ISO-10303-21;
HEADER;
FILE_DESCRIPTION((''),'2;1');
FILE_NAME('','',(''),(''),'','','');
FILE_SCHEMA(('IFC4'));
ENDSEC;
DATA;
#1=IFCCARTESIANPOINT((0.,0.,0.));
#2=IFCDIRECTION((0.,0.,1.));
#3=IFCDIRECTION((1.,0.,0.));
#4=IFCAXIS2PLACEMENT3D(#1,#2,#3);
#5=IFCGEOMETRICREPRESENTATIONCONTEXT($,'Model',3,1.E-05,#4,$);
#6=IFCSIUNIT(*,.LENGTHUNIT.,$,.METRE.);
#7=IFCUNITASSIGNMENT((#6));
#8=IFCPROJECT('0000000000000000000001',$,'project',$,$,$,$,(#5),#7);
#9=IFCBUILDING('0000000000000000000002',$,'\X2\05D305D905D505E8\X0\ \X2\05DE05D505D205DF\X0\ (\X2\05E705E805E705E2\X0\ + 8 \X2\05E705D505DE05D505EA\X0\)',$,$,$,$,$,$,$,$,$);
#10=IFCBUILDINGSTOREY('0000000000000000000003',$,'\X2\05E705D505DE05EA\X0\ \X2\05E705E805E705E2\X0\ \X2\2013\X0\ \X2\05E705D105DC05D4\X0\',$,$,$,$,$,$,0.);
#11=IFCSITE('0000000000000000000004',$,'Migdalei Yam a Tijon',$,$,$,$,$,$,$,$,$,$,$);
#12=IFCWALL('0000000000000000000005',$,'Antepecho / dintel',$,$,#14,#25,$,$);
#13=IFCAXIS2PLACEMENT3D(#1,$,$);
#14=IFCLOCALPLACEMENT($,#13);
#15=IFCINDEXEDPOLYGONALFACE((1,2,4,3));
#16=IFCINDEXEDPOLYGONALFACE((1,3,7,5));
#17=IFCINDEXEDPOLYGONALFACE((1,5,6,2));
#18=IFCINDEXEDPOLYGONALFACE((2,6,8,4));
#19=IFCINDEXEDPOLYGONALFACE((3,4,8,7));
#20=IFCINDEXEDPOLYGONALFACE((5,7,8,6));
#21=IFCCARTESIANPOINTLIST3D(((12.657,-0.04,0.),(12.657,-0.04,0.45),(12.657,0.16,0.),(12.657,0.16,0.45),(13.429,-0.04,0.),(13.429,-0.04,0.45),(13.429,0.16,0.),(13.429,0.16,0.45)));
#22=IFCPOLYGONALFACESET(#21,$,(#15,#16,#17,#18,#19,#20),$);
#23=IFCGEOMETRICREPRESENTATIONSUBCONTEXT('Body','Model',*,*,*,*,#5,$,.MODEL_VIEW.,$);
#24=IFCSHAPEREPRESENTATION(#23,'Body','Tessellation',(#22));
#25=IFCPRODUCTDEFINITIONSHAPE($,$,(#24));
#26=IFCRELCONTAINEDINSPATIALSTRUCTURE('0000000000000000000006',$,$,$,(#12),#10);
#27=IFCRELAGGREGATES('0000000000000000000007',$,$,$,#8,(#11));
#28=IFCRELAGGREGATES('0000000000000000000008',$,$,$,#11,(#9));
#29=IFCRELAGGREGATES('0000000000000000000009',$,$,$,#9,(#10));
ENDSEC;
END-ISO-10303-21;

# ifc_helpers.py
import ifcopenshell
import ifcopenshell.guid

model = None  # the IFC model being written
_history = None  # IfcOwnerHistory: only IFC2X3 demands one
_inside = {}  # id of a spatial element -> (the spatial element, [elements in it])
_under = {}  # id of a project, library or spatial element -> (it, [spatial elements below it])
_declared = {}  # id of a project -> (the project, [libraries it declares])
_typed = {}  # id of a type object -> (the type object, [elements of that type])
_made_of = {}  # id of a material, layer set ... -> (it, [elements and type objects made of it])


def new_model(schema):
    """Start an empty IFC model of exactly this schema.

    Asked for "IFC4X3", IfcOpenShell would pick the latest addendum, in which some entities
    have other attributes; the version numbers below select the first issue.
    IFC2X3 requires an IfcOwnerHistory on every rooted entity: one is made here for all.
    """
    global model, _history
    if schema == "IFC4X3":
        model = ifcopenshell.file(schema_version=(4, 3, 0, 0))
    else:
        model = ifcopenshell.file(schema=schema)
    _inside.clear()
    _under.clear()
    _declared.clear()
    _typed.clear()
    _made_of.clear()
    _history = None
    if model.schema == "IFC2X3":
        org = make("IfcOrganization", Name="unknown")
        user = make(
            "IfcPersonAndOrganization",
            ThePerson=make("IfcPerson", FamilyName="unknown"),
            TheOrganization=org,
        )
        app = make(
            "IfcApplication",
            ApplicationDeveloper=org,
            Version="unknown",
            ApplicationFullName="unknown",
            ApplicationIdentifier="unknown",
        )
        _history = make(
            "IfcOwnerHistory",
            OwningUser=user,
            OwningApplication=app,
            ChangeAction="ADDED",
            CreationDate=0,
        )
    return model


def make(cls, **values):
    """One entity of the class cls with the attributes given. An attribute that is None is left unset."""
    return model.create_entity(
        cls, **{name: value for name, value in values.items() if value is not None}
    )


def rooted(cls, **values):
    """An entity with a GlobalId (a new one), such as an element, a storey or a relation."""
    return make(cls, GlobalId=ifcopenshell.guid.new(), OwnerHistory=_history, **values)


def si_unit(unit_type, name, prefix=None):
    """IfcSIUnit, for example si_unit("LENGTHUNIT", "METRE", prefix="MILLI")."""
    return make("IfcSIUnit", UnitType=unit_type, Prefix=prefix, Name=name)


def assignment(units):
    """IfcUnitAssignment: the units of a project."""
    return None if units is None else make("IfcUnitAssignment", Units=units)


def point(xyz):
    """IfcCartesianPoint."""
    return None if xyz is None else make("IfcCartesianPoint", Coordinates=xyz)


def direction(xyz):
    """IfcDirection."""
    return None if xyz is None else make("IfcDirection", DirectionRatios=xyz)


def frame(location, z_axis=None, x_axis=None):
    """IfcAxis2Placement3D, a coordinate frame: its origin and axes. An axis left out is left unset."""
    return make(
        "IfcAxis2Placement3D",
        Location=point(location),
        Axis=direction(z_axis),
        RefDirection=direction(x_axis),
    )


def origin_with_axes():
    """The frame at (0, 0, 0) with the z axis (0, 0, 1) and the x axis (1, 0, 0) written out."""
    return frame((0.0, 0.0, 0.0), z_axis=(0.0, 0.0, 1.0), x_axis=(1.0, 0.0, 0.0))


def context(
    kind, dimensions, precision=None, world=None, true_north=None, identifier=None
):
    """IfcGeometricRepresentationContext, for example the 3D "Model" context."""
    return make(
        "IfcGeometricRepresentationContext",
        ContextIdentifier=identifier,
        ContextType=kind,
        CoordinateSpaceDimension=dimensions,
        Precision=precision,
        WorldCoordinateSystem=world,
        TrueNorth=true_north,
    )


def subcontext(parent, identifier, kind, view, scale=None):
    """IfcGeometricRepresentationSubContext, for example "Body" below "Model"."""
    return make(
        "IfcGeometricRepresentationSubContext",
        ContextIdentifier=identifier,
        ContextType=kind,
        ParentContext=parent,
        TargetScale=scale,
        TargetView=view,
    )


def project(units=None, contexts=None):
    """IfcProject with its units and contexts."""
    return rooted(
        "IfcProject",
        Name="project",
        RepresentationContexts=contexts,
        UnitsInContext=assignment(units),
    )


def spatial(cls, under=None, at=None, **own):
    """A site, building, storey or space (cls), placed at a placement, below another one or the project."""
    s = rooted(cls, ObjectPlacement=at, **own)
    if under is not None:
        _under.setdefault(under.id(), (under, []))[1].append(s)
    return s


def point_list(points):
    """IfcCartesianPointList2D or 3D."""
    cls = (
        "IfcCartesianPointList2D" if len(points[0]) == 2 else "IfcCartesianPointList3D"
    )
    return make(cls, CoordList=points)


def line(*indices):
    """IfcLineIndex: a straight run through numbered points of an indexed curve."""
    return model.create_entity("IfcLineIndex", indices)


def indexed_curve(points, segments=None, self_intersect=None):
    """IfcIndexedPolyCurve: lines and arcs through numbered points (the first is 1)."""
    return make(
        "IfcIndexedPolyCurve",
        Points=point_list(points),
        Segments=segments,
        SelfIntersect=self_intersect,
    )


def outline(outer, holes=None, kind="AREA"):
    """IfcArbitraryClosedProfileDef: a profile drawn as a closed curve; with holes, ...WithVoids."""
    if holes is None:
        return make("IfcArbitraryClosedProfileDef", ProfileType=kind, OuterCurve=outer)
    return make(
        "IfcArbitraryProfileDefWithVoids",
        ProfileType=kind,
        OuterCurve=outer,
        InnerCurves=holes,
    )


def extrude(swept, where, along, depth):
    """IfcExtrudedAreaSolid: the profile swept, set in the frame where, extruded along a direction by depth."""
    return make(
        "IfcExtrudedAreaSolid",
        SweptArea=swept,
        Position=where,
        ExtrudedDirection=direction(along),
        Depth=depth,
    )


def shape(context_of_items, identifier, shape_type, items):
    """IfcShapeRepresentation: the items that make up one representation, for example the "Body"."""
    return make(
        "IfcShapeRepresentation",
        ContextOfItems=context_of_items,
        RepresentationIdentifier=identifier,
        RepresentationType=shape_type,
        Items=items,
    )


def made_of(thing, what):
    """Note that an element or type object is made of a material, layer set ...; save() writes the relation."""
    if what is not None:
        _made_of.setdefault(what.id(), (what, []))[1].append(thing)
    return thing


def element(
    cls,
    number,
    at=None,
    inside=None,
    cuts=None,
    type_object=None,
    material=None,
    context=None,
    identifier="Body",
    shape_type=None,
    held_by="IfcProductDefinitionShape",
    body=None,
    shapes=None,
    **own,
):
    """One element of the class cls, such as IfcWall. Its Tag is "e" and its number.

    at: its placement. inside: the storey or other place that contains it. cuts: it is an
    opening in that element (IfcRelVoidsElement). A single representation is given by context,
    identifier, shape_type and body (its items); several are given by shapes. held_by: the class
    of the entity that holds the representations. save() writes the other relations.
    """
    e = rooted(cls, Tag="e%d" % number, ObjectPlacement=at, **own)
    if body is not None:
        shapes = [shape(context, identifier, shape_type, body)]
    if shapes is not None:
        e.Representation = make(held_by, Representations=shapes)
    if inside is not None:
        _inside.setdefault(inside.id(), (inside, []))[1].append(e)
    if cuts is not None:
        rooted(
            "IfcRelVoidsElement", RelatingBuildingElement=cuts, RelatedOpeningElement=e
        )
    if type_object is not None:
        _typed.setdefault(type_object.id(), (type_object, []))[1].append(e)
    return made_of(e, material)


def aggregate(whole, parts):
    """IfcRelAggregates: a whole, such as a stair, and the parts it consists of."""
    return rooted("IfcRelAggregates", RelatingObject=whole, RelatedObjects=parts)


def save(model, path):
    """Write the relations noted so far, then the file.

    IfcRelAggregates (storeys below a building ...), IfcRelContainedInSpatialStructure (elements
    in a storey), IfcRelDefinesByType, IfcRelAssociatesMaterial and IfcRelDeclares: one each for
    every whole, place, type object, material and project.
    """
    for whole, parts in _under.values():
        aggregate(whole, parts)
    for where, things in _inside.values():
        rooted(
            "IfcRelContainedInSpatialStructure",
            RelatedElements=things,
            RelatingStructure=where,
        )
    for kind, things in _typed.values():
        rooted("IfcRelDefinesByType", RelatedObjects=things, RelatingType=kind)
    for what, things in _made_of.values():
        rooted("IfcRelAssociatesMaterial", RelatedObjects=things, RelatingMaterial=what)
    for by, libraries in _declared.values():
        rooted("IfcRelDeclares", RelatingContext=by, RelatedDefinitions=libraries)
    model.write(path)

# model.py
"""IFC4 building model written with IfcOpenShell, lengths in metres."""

from ifc_helpers import new_model, si_unit, frame, origin_with_axes, context, subcontext, project, spatial, line, indexed_curve, outline, extrude, element, save


model = new_model("IFC4")

# Units and contexts
model_context = context("Model", 3, precision=1e-05, world=origin_with_axes())
body_context = subcontext(model_context, "Body", "Model", "MODEL_VIEW")
ifc_project = project(units=[si_unit("LENGTHUNIT", "METRE")], contexts=[model_context])

# Site, building, storey
site = spatial("IfcSite", under=ifc_project, Name="Migdalei Yam a Tijon")
building = spatial("IfcBuilding", under=site, Name="דיור מוגן (קרקע + 8 קומות)")
storey = spatial("IfcBuildingStorey", under=building, Name="קומת קרקע – קבלה", Elevation=0.0)

# Wall
element("IfcWall", 1, inside=storey, Name="Antepecho / dintel", context=body_context, shape_type="SweptSolid", body=[
    extrude(outline(indexed_curve([(0.0, 0.0), (0.772, 0.0), (0.772, 0.2), (0.0, 0.2)], segments=[line(1, 2, 3, 4, 1)])), frame((12.657, -0.04, 0.0), z_axis=(0.0, 0.0, 1.0), x_axis=(1.0, 0.0, 0.0)), (0.0, 0.0, 1.0), 0.45),
])

save(model, "model.ifc")
